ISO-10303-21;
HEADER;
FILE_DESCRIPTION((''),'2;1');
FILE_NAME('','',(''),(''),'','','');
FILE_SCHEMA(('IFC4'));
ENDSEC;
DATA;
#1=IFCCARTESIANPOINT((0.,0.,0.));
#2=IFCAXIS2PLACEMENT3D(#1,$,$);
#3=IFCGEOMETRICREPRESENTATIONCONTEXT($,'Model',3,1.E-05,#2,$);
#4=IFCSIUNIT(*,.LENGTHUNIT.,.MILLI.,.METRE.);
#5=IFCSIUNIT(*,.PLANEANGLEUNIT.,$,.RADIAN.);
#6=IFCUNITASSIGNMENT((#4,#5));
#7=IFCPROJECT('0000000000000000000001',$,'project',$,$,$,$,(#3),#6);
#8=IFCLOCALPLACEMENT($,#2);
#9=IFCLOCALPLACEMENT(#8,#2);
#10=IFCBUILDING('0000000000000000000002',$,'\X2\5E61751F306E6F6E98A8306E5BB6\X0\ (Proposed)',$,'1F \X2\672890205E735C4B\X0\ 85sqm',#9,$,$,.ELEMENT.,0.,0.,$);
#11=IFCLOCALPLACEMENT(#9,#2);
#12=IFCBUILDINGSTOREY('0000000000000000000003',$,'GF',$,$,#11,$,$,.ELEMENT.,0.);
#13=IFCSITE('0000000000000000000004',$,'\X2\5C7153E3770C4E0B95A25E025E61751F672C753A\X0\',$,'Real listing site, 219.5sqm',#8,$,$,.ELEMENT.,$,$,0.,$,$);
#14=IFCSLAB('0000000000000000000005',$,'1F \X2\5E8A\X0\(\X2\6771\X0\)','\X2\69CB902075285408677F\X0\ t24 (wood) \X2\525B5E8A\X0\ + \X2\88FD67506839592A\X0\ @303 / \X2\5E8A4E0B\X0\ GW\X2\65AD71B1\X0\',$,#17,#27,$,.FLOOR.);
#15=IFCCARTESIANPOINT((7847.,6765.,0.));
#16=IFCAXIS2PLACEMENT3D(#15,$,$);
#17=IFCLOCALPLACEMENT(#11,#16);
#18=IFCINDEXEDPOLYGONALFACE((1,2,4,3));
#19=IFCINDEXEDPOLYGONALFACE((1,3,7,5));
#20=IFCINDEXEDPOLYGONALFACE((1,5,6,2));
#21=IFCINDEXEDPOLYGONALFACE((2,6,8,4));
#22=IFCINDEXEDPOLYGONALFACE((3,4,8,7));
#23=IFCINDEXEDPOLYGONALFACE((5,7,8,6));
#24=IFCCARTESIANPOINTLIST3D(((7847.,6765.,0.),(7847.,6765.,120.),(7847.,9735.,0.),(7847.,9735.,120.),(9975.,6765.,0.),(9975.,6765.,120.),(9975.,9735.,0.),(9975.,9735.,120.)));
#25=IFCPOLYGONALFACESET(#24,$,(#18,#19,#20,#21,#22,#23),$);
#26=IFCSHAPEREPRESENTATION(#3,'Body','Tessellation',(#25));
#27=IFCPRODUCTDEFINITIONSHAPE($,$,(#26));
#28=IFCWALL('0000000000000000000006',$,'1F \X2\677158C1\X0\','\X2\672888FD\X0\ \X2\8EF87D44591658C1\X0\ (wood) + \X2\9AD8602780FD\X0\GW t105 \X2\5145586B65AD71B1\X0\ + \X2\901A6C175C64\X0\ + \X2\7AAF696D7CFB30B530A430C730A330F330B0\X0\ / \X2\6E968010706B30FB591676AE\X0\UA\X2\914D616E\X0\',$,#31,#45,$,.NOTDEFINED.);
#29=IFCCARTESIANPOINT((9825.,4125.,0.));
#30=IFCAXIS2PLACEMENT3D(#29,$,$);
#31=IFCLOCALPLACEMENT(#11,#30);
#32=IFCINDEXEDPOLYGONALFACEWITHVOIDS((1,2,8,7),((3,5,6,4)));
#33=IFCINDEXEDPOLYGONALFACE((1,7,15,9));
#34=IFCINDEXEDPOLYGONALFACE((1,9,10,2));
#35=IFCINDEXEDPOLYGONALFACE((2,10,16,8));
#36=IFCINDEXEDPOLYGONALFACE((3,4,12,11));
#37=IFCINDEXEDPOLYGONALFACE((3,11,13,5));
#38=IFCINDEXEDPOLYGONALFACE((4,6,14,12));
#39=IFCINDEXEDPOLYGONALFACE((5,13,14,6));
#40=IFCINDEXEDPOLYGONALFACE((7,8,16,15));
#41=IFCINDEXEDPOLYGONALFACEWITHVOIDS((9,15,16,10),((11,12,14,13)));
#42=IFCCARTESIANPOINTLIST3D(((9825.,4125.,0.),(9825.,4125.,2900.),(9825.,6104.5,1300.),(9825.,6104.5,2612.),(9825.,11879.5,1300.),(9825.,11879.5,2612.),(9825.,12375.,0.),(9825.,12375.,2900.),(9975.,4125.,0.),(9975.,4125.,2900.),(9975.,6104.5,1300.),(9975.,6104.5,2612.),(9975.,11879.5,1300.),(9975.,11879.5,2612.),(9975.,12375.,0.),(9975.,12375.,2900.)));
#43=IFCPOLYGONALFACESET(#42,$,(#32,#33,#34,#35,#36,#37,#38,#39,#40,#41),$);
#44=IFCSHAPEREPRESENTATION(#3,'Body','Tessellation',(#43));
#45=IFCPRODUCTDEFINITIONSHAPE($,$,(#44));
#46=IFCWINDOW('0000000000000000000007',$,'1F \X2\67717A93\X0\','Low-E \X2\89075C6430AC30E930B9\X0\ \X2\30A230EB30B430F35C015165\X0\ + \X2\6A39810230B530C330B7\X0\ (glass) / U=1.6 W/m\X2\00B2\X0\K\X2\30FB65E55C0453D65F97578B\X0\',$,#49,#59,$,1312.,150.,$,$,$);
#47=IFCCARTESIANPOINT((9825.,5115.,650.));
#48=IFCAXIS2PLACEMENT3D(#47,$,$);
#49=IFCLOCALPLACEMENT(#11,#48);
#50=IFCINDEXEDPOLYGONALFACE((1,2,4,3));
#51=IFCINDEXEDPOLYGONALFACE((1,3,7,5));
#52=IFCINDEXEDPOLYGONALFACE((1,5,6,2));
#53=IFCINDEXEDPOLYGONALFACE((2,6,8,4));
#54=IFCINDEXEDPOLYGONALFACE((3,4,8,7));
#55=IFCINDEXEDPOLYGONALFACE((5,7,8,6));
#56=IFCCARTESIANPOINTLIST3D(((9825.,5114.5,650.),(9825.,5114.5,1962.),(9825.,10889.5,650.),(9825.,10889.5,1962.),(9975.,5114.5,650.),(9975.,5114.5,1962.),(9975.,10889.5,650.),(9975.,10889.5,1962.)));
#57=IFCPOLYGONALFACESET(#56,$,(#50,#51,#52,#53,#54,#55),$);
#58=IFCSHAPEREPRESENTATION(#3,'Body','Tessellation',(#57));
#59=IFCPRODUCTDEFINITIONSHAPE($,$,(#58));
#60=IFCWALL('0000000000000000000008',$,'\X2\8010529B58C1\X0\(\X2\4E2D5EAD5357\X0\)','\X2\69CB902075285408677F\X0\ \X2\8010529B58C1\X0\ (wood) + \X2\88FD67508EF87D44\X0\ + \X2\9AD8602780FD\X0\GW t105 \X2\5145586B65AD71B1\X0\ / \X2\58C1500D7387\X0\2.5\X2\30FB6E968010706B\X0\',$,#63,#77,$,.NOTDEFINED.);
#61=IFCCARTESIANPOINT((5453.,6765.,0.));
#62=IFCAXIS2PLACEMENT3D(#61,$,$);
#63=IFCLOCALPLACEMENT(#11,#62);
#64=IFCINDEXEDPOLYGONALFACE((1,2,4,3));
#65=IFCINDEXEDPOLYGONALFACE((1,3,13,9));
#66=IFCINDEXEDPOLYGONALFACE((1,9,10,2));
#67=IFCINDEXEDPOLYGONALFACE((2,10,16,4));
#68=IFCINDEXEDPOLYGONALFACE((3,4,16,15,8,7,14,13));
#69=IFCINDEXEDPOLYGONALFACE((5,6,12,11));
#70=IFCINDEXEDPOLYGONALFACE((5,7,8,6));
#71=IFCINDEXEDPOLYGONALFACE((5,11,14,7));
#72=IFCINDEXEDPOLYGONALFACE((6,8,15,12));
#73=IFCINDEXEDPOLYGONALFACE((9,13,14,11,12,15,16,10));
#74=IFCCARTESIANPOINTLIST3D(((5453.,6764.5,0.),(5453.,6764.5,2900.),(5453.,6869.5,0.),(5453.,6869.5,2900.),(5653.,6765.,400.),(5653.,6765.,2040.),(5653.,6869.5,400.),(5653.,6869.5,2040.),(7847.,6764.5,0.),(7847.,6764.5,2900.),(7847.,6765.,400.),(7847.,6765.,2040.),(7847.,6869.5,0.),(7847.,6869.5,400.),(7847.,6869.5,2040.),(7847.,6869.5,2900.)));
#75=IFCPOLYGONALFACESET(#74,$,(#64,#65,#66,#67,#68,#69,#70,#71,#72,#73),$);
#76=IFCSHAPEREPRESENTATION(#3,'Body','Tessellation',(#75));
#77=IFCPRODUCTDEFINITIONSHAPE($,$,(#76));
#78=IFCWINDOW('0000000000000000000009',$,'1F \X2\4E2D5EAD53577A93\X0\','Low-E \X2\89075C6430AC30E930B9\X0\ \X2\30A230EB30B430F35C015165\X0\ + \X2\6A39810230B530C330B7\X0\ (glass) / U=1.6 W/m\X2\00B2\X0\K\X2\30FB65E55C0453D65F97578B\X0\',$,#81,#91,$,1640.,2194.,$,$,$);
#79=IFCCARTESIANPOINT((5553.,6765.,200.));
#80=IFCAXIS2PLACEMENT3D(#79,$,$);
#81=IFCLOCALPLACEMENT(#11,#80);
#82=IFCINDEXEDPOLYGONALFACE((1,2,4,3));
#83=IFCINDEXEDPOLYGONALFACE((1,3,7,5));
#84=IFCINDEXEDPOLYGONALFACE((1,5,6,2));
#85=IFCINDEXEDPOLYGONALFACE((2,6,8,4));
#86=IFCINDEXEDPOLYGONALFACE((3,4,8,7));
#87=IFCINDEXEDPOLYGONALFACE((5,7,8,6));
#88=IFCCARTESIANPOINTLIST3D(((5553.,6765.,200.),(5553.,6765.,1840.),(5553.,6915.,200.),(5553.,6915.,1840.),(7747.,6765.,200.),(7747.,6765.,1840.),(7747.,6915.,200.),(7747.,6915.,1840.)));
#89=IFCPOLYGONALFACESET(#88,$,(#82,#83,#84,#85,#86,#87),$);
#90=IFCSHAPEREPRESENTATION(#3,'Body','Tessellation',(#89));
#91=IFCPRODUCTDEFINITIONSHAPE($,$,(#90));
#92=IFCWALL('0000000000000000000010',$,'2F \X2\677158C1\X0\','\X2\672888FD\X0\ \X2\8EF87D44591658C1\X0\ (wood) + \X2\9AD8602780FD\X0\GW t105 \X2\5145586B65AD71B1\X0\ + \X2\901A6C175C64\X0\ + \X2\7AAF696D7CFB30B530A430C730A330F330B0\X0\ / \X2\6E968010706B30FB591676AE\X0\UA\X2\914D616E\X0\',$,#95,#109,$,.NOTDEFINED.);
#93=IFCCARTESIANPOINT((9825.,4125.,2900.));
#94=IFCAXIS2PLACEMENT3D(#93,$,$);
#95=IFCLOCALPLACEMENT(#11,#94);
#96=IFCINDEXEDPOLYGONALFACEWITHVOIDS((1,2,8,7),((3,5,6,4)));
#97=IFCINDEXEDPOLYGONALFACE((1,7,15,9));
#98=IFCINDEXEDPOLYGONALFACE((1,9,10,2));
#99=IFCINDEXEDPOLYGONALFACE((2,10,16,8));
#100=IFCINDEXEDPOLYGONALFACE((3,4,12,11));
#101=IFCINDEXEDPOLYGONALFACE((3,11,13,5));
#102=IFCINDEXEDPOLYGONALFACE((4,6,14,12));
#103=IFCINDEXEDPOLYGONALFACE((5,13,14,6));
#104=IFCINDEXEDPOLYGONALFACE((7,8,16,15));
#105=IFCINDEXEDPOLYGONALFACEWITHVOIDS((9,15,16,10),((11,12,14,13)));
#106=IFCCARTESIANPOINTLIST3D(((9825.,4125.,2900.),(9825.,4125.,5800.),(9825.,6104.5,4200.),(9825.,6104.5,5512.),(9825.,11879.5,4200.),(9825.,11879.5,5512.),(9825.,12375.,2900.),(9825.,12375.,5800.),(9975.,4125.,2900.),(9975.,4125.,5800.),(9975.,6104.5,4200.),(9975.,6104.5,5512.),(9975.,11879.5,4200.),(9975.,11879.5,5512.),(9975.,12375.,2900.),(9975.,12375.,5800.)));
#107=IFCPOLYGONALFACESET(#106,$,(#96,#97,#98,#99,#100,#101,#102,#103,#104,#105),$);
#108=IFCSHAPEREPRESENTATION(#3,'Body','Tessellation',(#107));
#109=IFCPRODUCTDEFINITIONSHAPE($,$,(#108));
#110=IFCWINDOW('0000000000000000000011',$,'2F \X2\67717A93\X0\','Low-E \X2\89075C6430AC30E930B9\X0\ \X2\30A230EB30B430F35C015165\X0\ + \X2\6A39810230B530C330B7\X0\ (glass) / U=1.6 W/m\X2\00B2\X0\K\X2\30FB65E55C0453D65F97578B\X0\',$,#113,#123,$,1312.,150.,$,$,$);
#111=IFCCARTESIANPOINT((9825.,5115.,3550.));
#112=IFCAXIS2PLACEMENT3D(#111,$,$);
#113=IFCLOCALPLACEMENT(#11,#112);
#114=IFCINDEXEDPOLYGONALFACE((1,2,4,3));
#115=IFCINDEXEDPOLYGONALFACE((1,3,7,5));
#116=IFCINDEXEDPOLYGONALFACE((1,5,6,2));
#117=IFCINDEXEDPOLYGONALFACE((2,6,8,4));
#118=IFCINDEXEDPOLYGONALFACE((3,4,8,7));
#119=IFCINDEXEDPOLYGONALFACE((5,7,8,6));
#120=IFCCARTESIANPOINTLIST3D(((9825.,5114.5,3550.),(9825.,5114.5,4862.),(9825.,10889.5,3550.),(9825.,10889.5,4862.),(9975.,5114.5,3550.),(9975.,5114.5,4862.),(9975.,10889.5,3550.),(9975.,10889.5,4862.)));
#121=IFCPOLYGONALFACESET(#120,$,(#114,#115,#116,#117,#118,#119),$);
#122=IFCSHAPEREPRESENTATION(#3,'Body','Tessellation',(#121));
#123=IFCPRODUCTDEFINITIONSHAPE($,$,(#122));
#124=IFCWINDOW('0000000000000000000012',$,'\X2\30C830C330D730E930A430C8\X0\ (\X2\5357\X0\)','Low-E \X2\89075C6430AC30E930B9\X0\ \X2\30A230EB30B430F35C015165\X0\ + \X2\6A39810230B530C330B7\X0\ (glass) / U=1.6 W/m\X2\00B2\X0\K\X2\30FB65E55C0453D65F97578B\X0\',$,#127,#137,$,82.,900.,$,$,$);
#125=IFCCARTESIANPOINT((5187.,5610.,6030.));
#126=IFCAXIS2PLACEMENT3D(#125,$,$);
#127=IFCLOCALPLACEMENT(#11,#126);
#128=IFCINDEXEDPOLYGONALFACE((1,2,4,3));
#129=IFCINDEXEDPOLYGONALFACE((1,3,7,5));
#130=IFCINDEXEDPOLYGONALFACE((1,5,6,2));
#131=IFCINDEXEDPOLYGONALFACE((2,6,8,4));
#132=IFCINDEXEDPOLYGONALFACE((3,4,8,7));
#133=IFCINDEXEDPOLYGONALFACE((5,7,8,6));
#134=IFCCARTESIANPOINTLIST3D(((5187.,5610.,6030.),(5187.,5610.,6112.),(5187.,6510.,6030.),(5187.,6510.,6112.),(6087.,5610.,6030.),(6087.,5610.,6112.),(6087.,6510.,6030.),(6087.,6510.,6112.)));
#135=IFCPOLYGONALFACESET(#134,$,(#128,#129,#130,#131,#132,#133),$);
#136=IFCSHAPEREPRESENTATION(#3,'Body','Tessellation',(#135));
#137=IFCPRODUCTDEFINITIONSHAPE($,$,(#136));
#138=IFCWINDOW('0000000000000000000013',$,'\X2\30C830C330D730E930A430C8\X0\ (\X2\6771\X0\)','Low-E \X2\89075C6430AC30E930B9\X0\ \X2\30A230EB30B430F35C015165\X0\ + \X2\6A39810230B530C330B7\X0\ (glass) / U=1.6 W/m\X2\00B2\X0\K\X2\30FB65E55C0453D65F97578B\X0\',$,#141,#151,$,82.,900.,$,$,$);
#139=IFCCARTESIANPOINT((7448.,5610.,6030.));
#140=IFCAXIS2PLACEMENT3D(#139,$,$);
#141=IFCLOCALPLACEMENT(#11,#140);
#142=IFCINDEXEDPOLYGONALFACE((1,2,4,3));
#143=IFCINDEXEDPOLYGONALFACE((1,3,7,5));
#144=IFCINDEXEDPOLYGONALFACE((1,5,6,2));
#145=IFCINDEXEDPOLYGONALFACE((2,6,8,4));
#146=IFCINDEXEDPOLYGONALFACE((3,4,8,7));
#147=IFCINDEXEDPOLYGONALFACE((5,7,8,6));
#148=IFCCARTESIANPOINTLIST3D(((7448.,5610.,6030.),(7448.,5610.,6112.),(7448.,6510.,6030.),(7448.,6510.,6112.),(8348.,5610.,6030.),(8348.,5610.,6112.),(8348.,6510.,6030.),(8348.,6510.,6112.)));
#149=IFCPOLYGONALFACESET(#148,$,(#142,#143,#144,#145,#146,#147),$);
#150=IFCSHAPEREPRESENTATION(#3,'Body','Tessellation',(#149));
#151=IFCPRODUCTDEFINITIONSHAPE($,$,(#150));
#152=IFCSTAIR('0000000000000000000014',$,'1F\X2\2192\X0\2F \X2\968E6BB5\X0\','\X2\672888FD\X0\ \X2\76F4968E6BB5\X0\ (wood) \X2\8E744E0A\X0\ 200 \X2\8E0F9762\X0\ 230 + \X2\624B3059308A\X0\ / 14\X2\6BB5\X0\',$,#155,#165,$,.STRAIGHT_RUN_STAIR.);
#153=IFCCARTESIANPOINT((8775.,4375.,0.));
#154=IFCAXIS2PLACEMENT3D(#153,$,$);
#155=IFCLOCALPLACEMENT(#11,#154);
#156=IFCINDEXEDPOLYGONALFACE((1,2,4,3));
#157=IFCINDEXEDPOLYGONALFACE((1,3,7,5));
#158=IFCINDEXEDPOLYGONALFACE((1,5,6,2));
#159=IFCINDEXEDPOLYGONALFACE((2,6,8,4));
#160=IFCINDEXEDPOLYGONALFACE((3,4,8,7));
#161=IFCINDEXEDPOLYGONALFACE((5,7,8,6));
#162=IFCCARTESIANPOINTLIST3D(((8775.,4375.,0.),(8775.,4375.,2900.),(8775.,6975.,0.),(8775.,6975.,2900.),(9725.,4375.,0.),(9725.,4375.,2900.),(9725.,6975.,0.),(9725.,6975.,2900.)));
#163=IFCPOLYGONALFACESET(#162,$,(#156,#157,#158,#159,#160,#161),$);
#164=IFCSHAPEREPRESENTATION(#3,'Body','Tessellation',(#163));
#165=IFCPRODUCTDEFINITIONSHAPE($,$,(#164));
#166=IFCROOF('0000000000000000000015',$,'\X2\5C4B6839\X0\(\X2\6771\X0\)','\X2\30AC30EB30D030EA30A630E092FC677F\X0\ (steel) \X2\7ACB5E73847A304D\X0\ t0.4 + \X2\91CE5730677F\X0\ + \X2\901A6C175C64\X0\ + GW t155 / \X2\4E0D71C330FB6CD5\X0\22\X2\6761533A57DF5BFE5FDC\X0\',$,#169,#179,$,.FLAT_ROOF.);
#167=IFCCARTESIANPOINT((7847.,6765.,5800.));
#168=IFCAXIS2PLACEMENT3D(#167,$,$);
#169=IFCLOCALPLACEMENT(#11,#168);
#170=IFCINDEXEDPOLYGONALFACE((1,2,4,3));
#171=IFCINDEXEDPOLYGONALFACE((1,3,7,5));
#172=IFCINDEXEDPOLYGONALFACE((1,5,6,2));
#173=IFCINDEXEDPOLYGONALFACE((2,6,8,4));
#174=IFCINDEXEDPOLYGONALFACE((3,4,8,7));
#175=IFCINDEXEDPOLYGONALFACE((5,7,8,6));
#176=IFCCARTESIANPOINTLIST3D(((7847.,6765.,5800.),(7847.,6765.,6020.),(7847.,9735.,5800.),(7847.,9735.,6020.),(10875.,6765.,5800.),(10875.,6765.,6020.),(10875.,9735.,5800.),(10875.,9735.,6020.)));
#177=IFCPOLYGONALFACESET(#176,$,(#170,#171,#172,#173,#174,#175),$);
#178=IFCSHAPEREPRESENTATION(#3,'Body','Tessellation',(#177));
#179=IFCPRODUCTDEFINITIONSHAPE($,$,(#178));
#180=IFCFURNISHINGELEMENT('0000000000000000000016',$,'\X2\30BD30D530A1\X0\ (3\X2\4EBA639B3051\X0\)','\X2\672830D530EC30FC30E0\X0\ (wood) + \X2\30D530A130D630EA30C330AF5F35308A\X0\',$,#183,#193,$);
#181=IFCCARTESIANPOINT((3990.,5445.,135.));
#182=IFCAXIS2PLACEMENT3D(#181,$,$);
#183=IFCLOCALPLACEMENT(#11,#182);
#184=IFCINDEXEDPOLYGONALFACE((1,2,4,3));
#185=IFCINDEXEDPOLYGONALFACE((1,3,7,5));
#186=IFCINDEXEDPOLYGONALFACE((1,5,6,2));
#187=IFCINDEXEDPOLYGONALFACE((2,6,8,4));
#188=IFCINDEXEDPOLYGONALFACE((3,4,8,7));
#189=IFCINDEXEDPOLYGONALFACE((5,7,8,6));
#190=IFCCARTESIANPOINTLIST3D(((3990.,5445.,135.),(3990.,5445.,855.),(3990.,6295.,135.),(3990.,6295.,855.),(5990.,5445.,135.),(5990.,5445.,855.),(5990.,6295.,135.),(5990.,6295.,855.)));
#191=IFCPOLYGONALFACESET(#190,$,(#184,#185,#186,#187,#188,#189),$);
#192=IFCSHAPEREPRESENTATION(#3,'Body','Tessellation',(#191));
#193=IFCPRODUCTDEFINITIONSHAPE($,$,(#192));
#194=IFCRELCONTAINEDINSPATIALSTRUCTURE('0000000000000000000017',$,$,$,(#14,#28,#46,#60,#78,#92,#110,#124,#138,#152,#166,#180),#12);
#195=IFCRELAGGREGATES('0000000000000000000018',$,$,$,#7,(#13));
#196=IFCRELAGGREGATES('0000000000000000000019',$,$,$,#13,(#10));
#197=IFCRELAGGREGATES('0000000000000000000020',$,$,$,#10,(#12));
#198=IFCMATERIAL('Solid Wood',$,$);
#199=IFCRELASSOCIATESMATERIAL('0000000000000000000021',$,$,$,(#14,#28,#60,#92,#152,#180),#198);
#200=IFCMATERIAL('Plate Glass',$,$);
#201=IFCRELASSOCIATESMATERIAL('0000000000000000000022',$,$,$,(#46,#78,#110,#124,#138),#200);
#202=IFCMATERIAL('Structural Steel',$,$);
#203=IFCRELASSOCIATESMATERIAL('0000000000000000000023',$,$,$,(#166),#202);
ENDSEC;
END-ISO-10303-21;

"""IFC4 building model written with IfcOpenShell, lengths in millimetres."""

from ifc_helpers import new_model, si_unit, frame, frame_2d, origin, place, context, project, spatial, rectangle, extrude, material, element, fill, save


model = new_model("IFC4")

# Units and contexts
model_context = context("Model", 3, precision=1e-05, world=origin())
ifc_project = project(units=[si_unit("LENGTHUNIT", "METRE", prefix="MILLI"), si_unit("PLANEANGLEUNIT", "RADIAN")], contexts=[model_context])

# Site, building, storey
site_placement = place(None, origin())
site = spatial("IfcSite", under=ifc_project, at=site_placement, Name="山口県下関市幡生本町", ObjectType="Real listing site, 219.5sqm", CompositionType="ELEMENT", RefElevation=0.0)
building_placement = place(site_placement, origin())
building = spatial("IfcBuilding", under=site, at=building_placement, Name="幡生の潮風の家 (Proposed)", ObjectType="1F 木造平屋 85sqm", CompositionType="ELEMENT", ElevationOfRefHeight=0.0, ElevationOfTerrain=0.0)
storey_placement = place(building_placement, origin())
storey = spatial("IfcBuildingStorey", under=building, at=storey_placement, Name="GF", CompositionType="ELEMENT", Elevation=0.0)

# Slab
ifc_material_1 = material(Name="Solid Wood")
slab_placement = place(storey_placement, frame((7847.0, 6765.0, 0.0)))
element("IfcSlab", 1, at=slab_placement, inside=storey, material=ifc_material_1, Name="1F 床(東)", Description="構造用合板 t24 (wood) 剛床 + 製材根太 @303 / 床下 GW断熱", PredefinedType="FLOOR", context=model_context, shape_type="SweptSolid", body=[
    extrude(rectangle(XDim=2128.0, YDim=2970.0, at=frame_2d((1064.0, 1485.0))), frame((7847.0, 6765.0, 0.0)), (0.0, 0.0, 1.0), 120.0),
])

# Walls, openings, windows
wall_1_placement = place(storey_placement, frame((9825.0, 4125.0, 0.0)))
wall_1 = element("IfcWall", 2, at=wall_1_placement, inside=storey, material=ifc_material_1, Name="1F 東壁", Description="木製 軸組外壁 (wood) + 高性能GW t105 充填断熱 + 通気層 + 窯業系サイディング / 準耐火・外皮UA配慮", PredefinedType="NOTDEFINED", context=model_context, shape_type="SweptSolid", body=[
    extrude(rectangle(XDim=150.0, YDim=8250.0, at=frame_2d((75.0, 4125.0))), frame((9825.0, 4125.0, 0.0)), (0.0, 0.0, 1.0), 2900.0),
])
opening_1_placement = place(storey_placement, frame((9825.0, 5115.0, 650.0)))
opening_1 = element("IfcOpeningElement", 3, at=opening_1_placement, cuts=wall_1, PredefinedType="NOTDEFINED", context=model_context, shape_type="SweptSolid", body=[
    extrude(rectangle(XDim=150.0, YDim=5775.0, at=frame_2d((75.0, 2887.0))), frame((9825.0, 5115.0, 650.0)), (0.0, 0.0, 1.0), 1312.0),
])
ifc_material_2 = material(Name="Plate Glass")
window_1_placement = place(storey_placement, frame((9825.0, 5115.0, 650.0)))
window_1 = element("IfcWindow", 4, at=window_1_placement, inside=storey, material=ifc_material_2, Name="1F 東窓", Description="Low-E 複層ガラス アルゴン封入 + 樹脂サッシ (glass) / U=1.6 W/m²K・日射取得型", OverallHeight=1312.0, OverallWidth=150.0, context=model_context, shape_type="SweptSolid", body=[
    extrude(rectangle(XDim=150.0, YDim=5775.0, at=frame_2d((75.0, 2887.0))), frame((9825.0, 5115.0, 650.0)), (0.0, 0.0, 1.0), 1312.0),
])
fill(opening_1, window_1)
wall_2_placement = place(storey_placement, frame((5453.0, 6765.0, 0.0)))
wall_2 = element("IfcWall", 5, at=wall_2_placement, inside=storey, material=ifc_material_1, Name="耐力壁(中庭南)", Description="構造用合板 耐力壁 (wood) + 製材軸組 + 高性能GW t105 充填断熱 / 壁倍率2.5・準耐火", PredefinedType="NOTDEFINED", context=model_context, shape_type="SweptSolid", body=[
    extrude(rectangle(XDim=2394.0, YDim=105.0, at=frame_2d((1197.0, 52.0))), frame((5453.0, 6765.0, 0.0)), (0.0, 0.0, 1.0), 2900.0),
])
opening_2_placement = place(storey_placement, frame((5553.0, 6765.0, 200.0)))
opening_2 = element("IfcOpeningElement", 6, at=opening_2_placement, cuts=wall_2, PredefinedType="NOTDEFINED", context=model_context, shape_type="SweptSolid", body=[
    extrude(rectangle(XDim=2194.0, YDim=150.0, at=frame_2d((1097.0, 75.0))), frame((5553.0, 6765.0, 200.0)), (0.0, 0.0, 1.0), 1640.0),
])
window_2_placement = place(storey_placement, frame((5553.0, 6765.0, 200.0)))
window_2 = element("IfcWindow", 7, at=window_2_placement, inside=storey, material=ifc_material_2, Name="1F 中庭南窓", Description="Low-E 複層ガラス アルゴン封入 + 樹脂サッシ (glass) / U=1.6 W/m²K・日射取得型", OverallHeight=1640.0, OverallWidth=2194.0, context=model_context, shape_type="SweptSolid", body=[
    extrude(rectangle(XDim=2194.0, YDim=150.0, at=frame_2d((1097.0, 75.0))), frame((5553.0, 6765.0, 200.0)), (0.0, 0.0, 1.0), 1640.0),
])
fill(opening_2, window_2)

# Wall, opening, window
wall_3_placement = place(storey_placement, frame((9825.0, 4125.0, 2900.0)))
wall_3 = element("IfcWall", 8, at=wall_3_placement, inside=storey, material=ifc_material_1, Name="2F 東壁", Description="木製 軸組外壁 (wood) + 高性能GW t105 充填断熱 + 通気層 + 窯業系サイディング / 準耐火・外皮UA配慮", PredefinedType="NOTDEFINED", context=model_context, shape_type="SweptSolid", body=[
    extrude(rectangle(XDim=150.0, YDim=8250.0, at=frame_2d((75.0, 4125.0))), frame((9825.0, 4125.0, 2900.0)), (0.0, 0.0, 1.0), 2900.0),
])
opening_3_placement = place(storey_placement, frame((9825.0, 5115.0, 3550.0)))
opening_3 = element("IfcOpeningElement", 9, at=opening_3_placement, cuts=wall_3, PredefinedType="NOTDEFINED", context=model_context, shape_type="SweptSolid", body=[
    extrude(rectangle(XDim=150.0, YDim=5775.0, at=frame_2d((75.0, 2887.0))), frame((9825.0, 5115.0, 3550.0)), (0.0, 0.0, 1.0), 1312.0),
])
window_3_placement = place(storey_placement, frame((9825.0, 5115.0, 3550.0)))
window_3 = element("IfcWindow", 10, at=window_3_placement, inside=storey, material=ifc_material_2, Name="2F 東窓", Description="Low-E 複層ガラス アルゴン封入 + 樹脂サッシ (glass) / U=1.6 W/m²K・日射取得型", OverallHeight=1312.0, OverallWidth=150.0, context=model_context, shape_type="SweptSolid", body=[
    extrude(rectangle(XDim=150.0, YDim=5775.0, at=frame_2d((75.0, 2887.0))), frame((9825.0, 5115.0, 3550.0)), (0.0, 0.0, 1.0), 1312.0),
])
fill(opening_3, window_3)

# Windows
window_4_placement = place(storey_placement, frame((5187.0, 5610.0, 6030.0)))
element("IfcWindow", 11, at=window_4_placement, inside=storey, material=ifc_material_2, Name="トップライト (南)", Description="Low-E 複層ガラス アルゴン封入 + 樹脂サッシ (glass) / U=1.6 W/m²K・日射取得型", OverallHeight=82.0, OverallWidth=900.0, context=model_context, shape_type="SweptSolid", body=[
    extrude(rectangle(XDim=900.0, YDim=900.0, at=frame_2d((450.0, 450.0))), frame((5187.0, 5610.0, 6030.0)), (0.0, 0.0, 1.0), 82.0),
])
window_5_placement = place(storey_placement, frame((7448.0, 5610.0, 6030.0)))
element("IfcWindow", 12, at=window_5_placement, inside=storey, material=ifc_material_2, Name="トップライト (東)", Description="Low-E 複層ガラス アルゴン封入 + 樹脂サッシ (glass) / U=1.6 W/m²K・日射取得型", OverallHeight=82.0, OverallWidth=900.0, context=model_context, shape_type="SweptSolid", body=[
    extrude(rectangle(XDim=900.0, YDim=900.0, at=frame_2d((450.0, 450.0))), frame((7448.0, 5610.0, 6030.0)), (0.0, 0.0, 1.0), 82.0),
])

# Stair
stair_placement = place(storey_placement, frame((8775.0, 4375.0, 0.0)))
element("IfcStair", 13, at=stair_placement, inside=storey, material=ifc_material_1, Name="1F→2F 階段", Description="木製 直階段 (wood) 蹴上 200 踏面 230 + 手すり / 14段", PredefinedType="STRAIGHT_RUN_STAIR", context=model_context, shape_type="SweptSolid", body=[
    extrude(rectangle(XDim=950.0, YDim=2600.0, at=frame_2d((475.0, 1300.0))), frame((8775.0, 4375.0, 0.0)), (0.0, 0.0, 1.0), 2900.0),
])

# Roof
ifc_material_3 = material(Name="Structural Steel")
roof_placement = place(storey_placement, frame((7847.0, 6765.0, 5800.0)))
element("IfcRoof", 14, at=roof_placement, inside=storey, material=ifc_material_3, Name="屋根(東)", Description="ガルバリウム鋼板 (steel) 立平葺き t0.4 + 野地板 + 通気層 + GW t155 / 不燃・法22条区域対応", PredefinedType="FLAT_ROOF", context=model_context, shape_type="SweptSolid", body=[
    extrude(rectangle(XDim=3028.0, YDim=2970.0, at=frame_2d((1514.0, 1485.0))), frame((7847.0, 6765.0, 5800.0)), (0.0, 0.0, 1.0), 220.0),
])

# Furnishing element
furnishing_1_placement = place(storey_placement, frame((3990.0, 5445.0, 135.0)))
element("IfcFurnishingElement", 15, at=furnishing_1_placement, inside=storey, material=ifc_material_1, Name="ソファ (3人掛け)", Description="木フレーム (wood) + ファブリック張り", context=model_context, shape_type="SweptSolid", body=[
    extrude(rectangle(XDim=2000.0, YDim=850.0, at=frame_2d((1000.0, 425.0))), frame((3990.0, 5445.0, 135.0)), (0.0, 0.0, 1.0), 720.0),
])

save(model, "model.ifc")
